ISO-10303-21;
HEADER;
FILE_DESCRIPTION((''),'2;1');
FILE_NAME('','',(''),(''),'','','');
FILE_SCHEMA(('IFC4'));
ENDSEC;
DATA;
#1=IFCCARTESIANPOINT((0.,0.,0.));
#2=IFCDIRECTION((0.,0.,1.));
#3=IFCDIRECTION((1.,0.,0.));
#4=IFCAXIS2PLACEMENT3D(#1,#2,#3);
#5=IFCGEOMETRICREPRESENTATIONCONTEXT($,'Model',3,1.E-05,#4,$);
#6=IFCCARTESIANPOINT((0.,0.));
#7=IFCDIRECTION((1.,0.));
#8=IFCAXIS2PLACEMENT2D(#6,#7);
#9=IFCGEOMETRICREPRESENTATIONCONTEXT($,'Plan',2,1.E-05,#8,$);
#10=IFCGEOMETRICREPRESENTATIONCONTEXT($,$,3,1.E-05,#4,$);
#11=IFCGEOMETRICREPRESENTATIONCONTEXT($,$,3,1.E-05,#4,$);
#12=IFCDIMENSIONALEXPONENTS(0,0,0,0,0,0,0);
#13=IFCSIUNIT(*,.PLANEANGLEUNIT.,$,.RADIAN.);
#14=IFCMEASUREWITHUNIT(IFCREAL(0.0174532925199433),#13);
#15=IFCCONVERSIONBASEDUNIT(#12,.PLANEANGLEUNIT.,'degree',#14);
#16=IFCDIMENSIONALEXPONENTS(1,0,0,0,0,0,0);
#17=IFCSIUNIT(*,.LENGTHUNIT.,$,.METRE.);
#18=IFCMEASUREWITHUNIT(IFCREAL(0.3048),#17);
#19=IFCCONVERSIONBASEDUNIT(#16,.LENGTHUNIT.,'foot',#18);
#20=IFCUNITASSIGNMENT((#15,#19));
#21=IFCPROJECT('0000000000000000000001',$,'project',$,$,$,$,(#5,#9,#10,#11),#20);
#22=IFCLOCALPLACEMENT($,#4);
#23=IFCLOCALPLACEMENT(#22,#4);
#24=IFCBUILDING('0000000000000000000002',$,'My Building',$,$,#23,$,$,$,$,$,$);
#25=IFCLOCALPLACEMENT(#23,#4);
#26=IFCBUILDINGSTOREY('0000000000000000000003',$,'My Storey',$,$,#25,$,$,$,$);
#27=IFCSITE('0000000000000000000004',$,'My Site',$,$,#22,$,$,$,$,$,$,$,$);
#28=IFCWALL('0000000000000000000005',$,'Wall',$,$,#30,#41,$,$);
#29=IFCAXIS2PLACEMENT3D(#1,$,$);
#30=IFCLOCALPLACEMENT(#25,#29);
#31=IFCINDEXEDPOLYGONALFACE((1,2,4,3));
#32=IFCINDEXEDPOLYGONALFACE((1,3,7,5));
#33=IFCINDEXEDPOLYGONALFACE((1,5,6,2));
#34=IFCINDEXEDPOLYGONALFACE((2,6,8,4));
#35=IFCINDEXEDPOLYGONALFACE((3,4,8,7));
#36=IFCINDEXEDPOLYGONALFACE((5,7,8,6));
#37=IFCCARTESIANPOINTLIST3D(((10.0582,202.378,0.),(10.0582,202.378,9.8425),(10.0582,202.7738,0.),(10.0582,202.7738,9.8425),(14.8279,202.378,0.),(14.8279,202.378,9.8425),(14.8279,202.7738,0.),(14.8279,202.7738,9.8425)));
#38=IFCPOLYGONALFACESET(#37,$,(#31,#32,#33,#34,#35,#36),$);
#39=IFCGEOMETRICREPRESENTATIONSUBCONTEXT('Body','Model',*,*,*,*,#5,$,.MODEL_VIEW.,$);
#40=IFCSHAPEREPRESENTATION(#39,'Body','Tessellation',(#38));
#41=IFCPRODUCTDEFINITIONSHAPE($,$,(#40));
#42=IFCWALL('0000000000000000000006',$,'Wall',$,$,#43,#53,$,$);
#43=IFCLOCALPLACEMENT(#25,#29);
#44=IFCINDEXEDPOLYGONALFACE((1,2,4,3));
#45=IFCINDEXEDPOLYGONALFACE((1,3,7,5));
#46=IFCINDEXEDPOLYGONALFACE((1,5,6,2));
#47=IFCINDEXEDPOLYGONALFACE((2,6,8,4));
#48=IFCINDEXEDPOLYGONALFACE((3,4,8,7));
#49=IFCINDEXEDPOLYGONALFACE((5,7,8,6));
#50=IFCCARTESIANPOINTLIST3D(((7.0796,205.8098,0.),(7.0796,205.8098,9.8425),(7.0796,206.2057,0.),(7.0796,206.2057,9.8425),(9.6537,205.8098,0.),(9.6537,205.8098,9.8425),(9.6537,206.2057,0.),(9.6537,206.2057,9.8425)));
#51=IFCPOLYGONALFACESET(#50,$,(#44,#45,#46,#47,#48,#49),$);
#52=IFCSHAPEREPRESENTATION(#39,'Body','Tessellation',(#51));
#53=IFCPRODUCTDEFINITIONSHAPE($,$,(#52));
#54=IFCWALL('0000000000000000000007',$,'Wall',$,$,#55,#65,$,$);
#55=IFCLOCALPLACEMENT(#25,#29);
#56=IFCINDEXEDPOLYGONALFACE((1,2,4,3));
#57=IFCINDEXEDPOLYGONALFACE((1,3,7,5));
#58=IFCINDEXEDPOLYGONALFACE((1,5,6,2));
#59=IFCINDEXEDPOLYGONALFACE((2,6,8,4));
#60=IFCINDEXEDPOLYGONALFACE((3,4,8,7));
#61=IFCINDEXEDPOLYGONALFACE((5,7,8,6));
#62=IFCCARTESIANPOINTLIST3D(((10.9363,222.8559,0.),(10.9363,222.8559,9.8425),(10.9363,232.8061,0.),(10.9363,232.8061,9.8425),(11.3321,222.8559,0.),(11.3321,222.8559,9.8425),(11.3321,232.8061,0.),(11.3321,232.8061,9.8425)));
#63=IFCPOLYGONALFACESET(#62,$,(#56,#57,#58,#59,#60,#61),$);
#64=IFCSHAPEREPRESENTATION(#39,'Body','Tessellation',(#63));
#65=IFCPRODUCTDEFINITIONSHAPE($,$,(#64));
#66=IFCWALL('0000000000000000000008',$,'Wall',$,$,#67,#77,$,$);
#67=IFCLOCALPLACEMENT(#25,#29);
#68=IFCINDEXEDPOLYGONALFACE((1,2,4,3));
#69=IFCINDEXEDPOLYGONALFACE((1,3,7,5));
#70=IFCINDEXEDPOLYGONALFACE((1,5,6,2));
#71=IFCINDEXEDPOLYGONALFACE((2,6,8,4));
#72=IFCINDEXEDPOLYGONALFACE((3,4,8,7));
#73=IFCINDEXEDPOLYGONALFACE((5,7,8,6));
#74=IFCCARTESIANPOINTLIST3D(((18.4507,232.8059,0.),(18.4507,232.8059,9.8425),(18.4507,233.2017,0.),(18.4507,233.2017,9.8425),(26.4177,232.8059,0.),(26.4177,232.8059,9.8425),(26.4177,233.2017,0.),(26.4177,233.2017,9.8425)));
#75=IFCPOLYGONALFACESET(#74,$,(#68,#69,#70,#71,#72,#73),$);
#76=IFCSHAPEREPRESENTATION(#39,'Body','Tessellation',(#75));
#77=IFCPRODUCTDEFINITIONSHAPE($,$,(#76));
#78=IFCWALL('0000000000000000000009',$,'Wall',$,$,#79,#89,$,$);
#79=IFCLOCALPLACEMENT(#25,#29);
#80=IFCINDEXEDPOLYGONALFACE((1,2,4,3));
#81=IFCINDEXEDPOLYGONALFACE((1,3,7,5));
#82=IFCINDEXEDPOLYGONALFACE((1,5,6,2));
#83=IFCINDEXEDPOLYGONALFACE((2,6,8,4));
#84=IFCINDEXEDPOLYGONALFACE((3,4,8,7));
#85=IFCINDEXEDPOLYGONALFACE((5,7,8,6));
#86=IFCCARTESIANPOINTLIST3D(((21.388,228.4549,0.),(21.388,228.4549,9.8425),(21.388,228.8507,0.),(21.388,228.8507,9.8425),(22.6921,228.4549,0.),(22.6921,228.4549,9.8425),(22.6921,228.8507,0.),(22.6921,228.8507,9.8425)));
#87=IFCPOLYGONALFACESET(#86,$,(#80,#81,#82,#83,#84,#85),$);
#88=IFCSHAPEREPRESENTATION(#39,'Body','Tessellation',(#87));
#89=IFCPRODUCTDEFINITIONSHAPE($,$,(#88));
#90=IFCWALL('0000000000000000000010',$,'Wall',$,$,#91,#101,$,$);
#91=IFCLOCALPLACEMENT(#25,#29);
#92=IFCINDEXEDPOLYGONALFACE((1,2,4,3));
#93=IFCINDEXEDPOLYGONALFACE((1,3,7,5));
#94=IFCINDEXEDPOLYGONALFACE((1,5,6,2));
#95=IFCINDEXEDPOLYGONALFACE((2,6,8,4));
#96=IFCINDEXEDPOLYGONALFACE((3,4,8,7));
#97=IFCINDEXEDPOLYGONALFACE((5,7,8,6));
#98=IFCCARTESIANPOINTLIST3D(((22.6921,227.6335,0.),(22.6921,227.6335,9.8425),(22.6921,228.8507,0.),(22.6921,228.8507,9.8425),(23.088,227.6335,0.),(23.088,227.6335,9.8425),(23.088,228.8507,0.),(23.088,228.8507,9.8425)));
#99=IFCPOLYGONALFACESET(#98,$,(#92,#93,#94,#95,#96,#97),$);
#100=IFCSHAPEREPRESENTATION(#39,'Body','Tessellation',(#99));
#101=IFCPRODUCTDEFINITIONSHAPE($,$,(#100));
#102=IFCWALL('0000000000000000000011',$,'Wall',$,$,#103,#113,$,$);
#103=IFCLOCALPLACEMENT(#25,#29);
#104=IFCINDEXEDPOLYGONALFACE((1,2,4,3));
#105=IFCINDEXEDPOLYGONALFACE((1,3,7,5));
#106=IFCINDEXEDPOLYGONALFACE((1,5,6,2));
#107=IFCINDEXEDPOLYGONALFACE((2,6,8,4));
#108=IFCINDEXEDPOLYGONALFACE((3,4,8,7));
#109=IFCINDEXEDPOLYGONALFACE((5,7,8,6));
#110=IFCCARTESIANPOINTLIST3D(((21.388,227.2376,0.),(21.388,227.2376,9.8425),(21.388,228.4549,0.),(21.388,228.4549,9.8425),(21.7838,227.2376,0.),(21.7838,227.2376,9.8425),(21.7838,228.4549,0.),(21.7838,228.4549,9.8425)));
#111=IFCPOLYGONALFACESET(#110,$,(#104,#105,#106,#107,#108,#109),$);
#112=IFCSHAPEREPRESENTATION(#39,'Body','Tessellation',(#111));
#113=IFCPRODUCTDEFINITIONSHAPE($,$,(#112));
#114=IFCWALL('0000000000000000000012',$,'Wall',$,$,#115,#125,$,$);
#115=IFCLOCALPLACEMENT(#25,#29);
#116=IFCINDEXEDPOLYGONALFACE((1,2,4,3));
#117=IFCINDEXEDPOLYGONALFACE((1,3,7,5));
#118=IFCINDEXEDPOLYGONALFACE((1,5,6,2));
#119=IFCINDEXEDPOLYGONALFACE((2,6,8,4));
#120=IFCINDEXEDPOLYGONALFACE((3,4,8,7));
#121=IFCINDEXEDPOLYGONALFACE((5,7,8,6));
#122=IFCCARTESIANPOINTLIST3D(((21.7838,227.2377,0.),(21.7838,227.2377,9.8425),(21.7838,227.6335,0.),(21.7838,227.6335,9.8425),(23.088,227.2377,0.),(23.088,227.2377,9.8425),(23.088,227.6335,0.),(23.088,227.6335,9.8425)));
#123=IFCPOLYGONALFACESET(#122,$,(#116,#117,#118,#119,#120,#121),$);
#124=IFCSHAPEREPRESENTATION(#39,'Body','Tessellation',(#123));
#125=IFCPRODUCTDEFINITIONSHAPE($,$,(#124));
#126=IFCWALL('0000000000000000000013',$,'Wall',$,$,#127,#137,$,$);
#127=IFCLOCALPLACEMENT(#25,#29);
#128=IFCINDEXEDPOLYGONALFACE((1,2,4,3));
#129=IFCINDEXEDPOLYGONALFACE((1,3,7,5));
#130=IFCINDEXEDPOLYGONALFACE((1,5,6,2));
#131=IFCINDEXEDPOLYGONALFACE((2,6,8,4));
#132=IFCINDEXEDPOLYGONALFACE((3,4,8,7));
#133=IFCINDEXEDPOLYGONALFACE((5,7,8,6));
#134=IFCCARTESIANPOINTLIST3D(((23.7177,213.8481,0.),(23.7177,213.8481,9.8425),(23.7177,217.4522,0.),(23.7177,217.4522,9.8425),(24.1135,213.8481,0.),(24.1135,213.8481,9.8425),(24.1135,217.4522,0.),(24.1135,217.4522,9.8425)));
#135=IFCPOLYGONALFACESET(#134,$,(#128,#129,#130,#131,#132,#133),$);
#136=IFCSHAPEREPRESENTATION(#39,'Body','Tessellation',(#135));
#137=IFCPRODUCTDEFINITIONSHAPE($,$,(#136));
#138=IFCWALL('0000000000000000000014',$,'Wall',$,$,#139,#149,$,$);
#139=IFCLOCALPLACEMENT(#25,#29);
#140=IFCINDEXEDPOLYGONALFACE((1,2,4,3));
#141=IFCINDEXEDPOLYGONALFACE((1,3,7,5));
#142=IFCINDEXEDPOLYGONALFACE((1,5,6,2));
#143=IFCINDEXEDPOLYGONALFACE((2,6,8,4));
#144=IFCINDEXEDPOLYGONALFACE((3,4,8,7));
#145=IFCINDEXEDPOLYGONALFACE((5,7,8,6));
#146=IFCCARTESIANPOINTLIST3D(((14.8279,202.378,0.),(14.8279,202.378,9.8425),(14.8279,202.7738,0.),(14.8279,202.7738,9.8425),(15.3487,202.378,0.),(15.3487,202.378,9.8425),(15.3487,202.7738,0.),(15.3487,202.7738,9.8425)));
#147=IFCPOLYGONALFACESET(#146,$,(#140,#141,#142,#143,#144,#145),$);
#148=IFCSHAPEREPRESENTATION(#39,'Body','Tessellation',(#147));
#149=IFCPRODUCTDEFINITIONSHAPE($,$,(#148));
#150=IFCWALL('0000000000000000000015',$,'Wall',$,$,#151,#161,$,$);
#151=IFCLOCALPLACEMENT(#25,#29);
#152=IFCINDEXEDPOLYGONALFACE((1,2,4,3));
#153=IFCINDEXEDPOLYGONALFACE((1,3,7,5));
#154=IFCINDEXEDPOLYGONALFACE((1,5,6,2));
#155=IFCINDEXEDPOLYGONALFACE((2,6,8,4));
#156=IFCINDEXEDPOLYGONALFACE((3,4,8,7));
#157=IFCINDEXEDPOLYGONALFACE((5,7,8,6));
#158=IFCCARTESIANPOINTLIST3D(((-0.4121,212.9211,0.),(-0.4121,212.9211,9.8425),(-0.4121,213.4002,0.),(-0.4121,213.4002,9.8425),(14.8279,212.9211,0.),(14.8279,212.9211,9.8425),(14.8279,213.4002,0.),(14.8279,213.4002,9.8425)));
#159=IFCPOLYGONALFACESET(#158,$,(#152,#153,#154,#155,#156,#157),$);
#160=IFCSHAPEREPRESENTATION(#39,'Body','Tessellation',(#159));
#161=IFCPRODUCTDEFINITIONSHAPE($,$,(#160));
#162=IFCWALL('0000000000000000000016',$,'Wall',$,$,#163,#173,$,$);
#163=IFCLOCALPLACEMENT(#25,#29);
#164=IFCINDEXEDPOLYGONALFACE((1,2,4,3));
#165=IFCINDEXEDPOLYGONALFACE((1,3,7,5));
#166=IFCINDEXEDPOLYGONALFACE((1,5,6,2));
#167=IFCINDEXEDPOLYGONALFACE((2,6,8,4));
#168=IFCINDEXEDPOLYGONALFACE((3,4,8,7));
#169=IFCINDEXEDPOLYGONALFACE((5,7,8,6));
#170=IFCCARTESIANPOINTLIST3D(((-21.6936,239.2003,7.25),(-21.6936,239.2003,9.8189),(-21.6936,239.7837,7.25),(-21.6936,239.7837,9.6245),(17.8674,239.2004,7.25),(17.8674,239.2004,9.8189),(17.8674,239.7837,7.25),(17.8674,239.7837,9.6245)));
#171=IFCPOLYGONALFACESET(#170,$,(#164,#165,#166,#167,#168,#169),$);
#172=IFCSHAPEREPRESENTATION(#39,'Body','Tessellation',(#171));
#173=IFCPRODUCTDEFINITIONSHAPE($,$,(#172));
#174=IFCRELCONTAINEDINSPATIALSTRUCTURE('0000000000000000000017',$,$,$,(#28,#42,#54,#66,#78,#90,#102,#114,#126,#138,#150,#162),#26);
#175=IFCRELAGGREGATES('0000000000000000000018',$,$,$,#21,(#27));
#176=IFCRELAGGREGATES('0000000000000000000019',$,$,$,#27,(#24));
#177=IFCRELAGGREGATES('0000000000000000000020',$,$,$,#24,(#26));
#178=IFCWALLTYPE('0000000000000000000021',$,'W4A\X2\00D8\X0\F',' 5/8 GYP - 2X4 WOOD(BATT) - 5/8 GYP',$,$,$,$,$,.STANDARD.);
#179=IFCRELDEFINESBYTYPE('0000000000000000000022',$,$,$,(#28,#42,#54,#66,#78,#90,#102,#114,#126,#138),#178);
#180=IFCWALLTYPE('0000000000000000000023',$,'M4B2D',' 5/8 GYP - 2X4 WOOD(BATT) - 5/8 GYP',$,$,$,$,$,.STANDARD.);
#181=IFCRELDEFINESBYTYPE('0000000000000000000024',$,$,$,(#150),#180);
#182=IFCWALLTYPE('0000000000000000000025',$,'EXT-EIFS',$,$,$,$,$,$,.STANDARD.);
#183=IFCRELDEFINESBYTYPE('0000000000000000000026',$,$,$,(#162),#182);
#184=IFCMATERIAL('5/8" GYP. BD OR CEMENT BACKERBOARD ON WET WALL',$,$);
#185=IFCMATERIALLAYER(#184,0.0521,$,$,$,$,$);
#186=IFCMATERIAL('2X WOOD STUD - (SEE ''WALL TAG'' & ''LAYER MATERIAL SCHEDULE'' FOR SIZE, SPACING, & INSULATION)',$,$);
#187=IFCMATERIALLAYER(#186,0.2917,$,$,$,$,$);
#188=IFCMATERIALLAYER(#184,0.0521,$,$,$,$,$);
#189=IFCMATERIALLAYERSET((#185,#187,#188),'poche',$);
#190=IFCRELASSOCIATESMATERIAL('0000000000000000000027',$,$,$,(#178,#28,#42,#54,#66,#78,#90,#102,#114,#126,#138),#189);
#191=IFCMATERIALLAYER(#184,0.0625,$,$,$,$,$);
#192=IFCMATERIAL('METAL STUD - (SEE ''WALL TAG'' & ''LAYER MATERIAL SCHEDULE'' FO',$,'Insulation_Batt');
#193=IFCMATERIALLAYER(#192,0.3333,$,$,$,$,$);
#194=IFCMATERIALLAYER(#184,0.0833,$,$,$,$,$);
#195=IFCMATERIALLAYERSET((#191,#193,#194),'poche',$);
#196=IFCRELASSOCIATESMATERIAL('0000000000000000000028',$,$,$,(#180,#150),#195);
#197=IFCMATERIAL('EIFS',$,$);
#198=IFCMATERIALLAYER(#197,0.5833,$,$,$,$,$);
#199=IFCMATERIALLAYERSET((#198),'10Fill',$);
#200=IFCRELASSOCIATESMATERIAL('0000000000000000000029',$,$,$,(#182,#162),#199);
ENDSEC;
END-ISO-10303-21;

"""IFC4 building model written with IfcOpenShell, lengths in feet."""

from ifc_helpers import new_model, entity, si_unit, converted_unit, frame, origin_with_axes, origin_2d_with_axis, place, context, subcontext, project, spatial, indexed_curve, outline, extrude, clip, halfspace, material, layer, layer_set, layer_usage, type_object, element, save


model = new_model("IFC4")

# Units and contexts
model_context = context("Model", 3, precision=1e-05, world=origin_with_axes())
plan_context = context("Plan", 2, precision=1e-05, world=origin_2d_with_axis())
context_of_model_1 = context(None, 3, precision=1e-05, world=origin_with_axes())
context_of_model_2 = context(None, 3, precision=1e-05, world=origin_with_axes())
body_context = subcontext(model_context, "Body", "Model", "MODEL_VIEW")
ifc_project = project(units=[converted_unit("PLANEANGLEUNIT", "degree", entity("IfcReal", 0.0174532925199433), si_unit("PLANEANGLEUNIT", "RADIAN"), dimensions=[0, 0, 0, 0, 0, 0, 0]), converted_unit("LENGTHUNIT", "foot", entity("IfcReal", 0.3048), si_unit("LENGTHUNIT", "METRE"), dimensions=[1, 0, 0, 0, 0, 0, 0])], contexts=[model_context, plan_context, context_of_model_1, context_of_model_2])

# Site, building, storey
site_placement = place(None, origin_with_axes())
site = spatial("IfcSite", under=ifc_project, at=site_placement, Name="My Site")
building_placement = place(site_placement, origin_with_axes())
building = spatial("IfcBuilding", under=site, at=building_placement, Name="My Building")
storey_placement = place(building_placement, origin_with_axes())
storey = spatial("IfcBuildingStorey", under=building, at=storey_placement, Name="My Storey")

# Walls
ifc_material_1 = material(Name="5/8\" GYP. BD OR CEMENT BACKERBOARD ON WET WALL")
ifc_layer_1 = layer(ifc_material_1, 0.0521)
ifc_material_2 = material(Name="2X WOOD STUD - (SEE 'WALL TAG' & 'LAYER MATERIAL SCHEDULE' FOR SIZE, SPACING, & INSULATION)")
ifc_layer_2 = layer(ifc_material_2, 0.2917)
ifc_layer_3 = layer(ifc_material_1, 0.0521)
ifc_layer_set_1 = layer_set([ifc_layer_1, ifc_layer_2, ifc_layer_3], Name="poche")
ifc_layer_usage_1 = layer_usage(ifc_layer_set_1, "AXIS2", "POSITIVE", 0.0)
wall_type_1 = type_object("IfcWallType", Name="W4AØF", Description=" 5/8 GYP - 2X4 WOOD(BATT) - 5/8 GYP", PredefinedType="STANDARD", material=ifc_layer_set_1)
wall_1_placement = place(storey_placement, frame((10.0582, 202.378, 0.0), z_axis=(0.0, 0.0, 1.0), x_axis=(1.0, 0.0, 0.0)))
element("IfcWall", 1, at=wall_1_placement, inside=storey, type_object=wall_type_1, material=ifc_layer_usage_1, Name="Wall", context=body_context, shape_type="SweptSolid", body=[
    extrude(outline(indexed_curve([(0.0, 0.0), (0.0, 0.3958), (4.7697, 0.3958), (4.7697, 0.0), (0.0, 0.0)], self_intersect=False)), origin_with_axes(), (0.0, 0.0, 1.0), 9.8425),
])
ifc_layer_usage_2 = layer_usage(ifc_layer_set_1, "AXIS2", "POSITIVE", 0.0)
wall_2_placement = place(storey_placement, frame((9.6537, 206.2057, 0.0), z_axis=(0.0, 0.0, 1.0), x_axis=(-1.0, 0.0, 0.0)))
element("IfcWall", 2, at=wall_2_placement, inside=storey, type_object=wall_type_1, material=ifc_layer_usage_2, Name="Wall", context=body_context, shape_type="SweptSolid", body=[
    extrude(outline(indexed_curve([(0.0, 0.0), (0.0, 0.3958), (2.5741, 0.3958), (2.5741, 0.0), (0.0, 0.0)], self_intersect=False)), origin_with_axes(), (0.0, 0.0, 1.0), 9.8425),
])
ifc_layer_usage_3 = layer_usage(ifc_layer_set_1, "AXIS2", "POSITIVE", 0.0)
wall_3_placement = place(storey_placement, frame((10.9363, 232.8061, 0.0), z_axis=(0.0, 0.0, 1.0), x_axis=(-0.000001, -1.0, 0.0)))
element("IfcWall", 3, at=wall_3_placement, inside=storey, type_object=wall_type_1, material=ifc_layer_usage_3, Name="Wall", context=body_context, shape_type="SweptSolid", body=[
    extrude(outline(indexed_curve([(0.0, 0.0), (0.0, 0.3958), (9.9502, 0.3958), (9.9502, 0.0), (0.0, 0.0)], self_intersect=False)), origin_with_axes(), (0.0, 0.0, 1.0), 9.8425),
])
ifc_layer_usage_4 = layer_usage(ifc_layer_set_1, "AXIS2", "POSITIVE", 0.0)
wall_4_placement = place(storey_placement, frame((18.4507, 232.8059, 0.0), z_axis=(0.0, 0.0, 1.0), x_axis=(1.0, 0.0, 0.0)))
element("IfcWall", 4, at=wall_4_placement, inside=storey, type_object=wall_type_1, material=ifc_layer_usage_4, Name="Wall", context=body_context, shape_type="SweptSolid", body=[
    extrude(outline(indexed_curve([(0.0, 0.0), (0.0, 0.3958), (7.967, 0.3958), (7.967, 0.0), (0.0, 0.0)], self_intersect=False)), origin_with_axes(), (0.0, 0.0, 1.0), 9.8425),
])

# Walls
ifc_layer_usage_5 = layer_usage(ifc_layer_set_1, "AXIS2", "POSITIVE", 0.0)
wall_5_placement = place(storey_placement, frame((22.6921, 228.8507, 0.0), z_axis=(0.0, 0.0, 1.0), x_axis=(-1.0, 0.0, 0.0)))
element("IfcWall", 5, at=wall_5_placement, inside=storey, type_object=wall_type_1, material=ifc_layer_usage_5, Name="Wall", context=body_context, shape_type="SweptSolid", body=[
    extrude(outline(indexed_curve([(0.0, 0.0), (0.0, 0.3958), (1.3042, 0.3958), (1.3042, 0.0), (0.0, 0.0)], self_intersect=False)), origin_with_axes(), (0.0, 0.0, 1.0), 9.8425),
])
ifc_layer_usage_6 = layer_usage(ifc_layer_set_1, "AXIS2", "POSITIVE", 0.0)
wall_6_placement = place(storey_placement, frame((23.088, 227.6335, 0.0), z_axis=(0.0, 0.0, 1.0), x_axis=(0.0, 1.0, 0.0)))
element("IfcWall", 6, at=wall_6_placement, inside=storey, type_object=wall_type_1, material=ifc_layer_usage_6, Name="Wall", context=body_context, shape_type="SweptSolid", body=[
    extrude(outline(indexed_curve([(0.0, 0.0), (0.0, 0.3958), (1.2172, 0.3958), (1.2172, 0.0), (0.0, 0.0)], self_intersect=False)), origin_with_axes(), (0.0, 0.0, 1.0), 9.8425),
])
ifc_layer_usage_7 = layer_usage(ifc_layer_set_1, "AXIS2", "POSITIVE", 0.0)
wall_7_placement = place(storey_placement, frame((21.388, 228.4549, 0.0), z_axis=(0.0, 0.0, 1.0), x_axis=(0.0, -1.0, 0.0)))
element("IfcWall", 7, at=wall_7_placement, inside=storey, type_object=wall_type_1, material=ifc_layer_usage_7, Name="Wall", context=body_context, shape_type="SweptSolid", body=[
    extrude(outline(indexed_curve([(0.0, 0.0), (0.0, 0.3958), (1.2172, 0.3958), (1.2172, 0.0), (0.0, 0.0)], self_intersect=False)), origin_with_axes(), (0.0, 0.0, 1.0), 9.8425),
])
ifc_layer_usage_8 = layer_usage(ifc_layer_set_1, "AXIS2", "POSITIVE", 0.0)
wall_8_placement = place(storey_placement, frame((21.7838, 227.2377, 0.0), z_axis=(0.0, 0.0, 1.0), x_axis=(1.0, 0.0, 0.0)))
element("IfcWall", 8, at=wall_8_placement, inside=storey, type_object=wall_type_1, material=ifc_layer_usage_8, Name="Wall", context=body_context, shape_type="SweptSolid", body=[
    extrude(outline(indexed_curve([(0.0, 0.0), (0.0, 0.3958), (1.3042, 0.3958), (1.3042, 0.0), (0.0, 0.0)], self_intersect=False)), origin_with_axes(), (0.0, 0.0, 1.0), 9.8425),
])
ifc_layer_usage_9 = layer_usage(ifc_layer_set_1, "AXIS2", "POSITIVE", 0.0)
wall_9_placement = place(storey_placement, frame((23.7177, 217.4522, 0.0), z_axis=(0.0, 0.0, 1.0), x_axis=(0.0, -1.0, 0.0)))
element("IfcWall", 9, at=wall_9_placement, inside=storey, type_object=wall_type_1, material=ifc_layer_usage_9, Name="Wall", context=body_context, shape_type="SweptSolid", body=[
    extrude(outline(indexed_curve([(0.0, 0.0), (0.0, 0.3958), (3.6041, 0.3958), (3.6041, 0.0), (0.0, 0.0)], self_intersect=False)), origin_with_axes(), (0.0, 0.0, 1.0), 9.8425),
])

# Walls
ifc_layer_usage_10 = layer_usage(ifc_layer_set_1, "AXIS2", "POSITIVE", 0.0)
wall_10_placement = place(storey_placement, frame((15.3487, 202.7738, 0.0), z_axis=(0.0, 0.0, 1.0), x_axis=(-1.0, 0.0, 0.0)))
element("IfcWall", 10, at=wall_10_placement, inside=storey, type_object=wall_type_1, material=ifc_layer_usage_10, Name="Wall", context=body_context, shape_type="SweptSolid", body=[
    extrude(outline(indexed_curve([(0.0, 0.0), (0.0, 0.3958), (0.5208, 0.3958), (0.5208, 0.0), (0.0, 0.0)], self_intersect=False)), origin_with_axes(), (0.0, 0.0, 1.0), 9.8425),
])
ifc_layer_4 = layer(ifc_material_1, 0.0625)
ifc_material_3 = material(Name="METAL STUD - (SEE 'WALL TAG' & 'LAYER MATERIAL SCHEDULE' FO", Category="Insulation_Batt")
ifc_layer_5 = layer(ifc_material_3, 0.3333)
ifc_layer_6 = layer(ifc_material_1, 0.0833)
ifc_layer_set_2 = layer_set([ifc_layer_4, ifc_layer_5, ifc_layer_6], Name="poche")
ifc_layer_usage_11 = layer_usage(ifc_layer_set_2, "AXIS2", "POSITIVE", 0.0)
wall_type_2 = type_object("IfcWallType", Name="M4B2D", Description=" 5/8 GYP - 2X4 WOOD(BATT) - 5/8 GYP", PredefinedType="STANDARD", material=ifc_layer_set_2)
wall_11_placement = place(storey_placement, frame((14.8279, 213.4002, 0.0), z_axis=(0.0, 0.0, 1.0), x_axis=(-1.0, 0.0, 0.0)))
element("IfcWall", 11, at=wall_11_placement, inside=storey, type_object=wall_type_2, material=ifc_layer_usage_11, Name="Wall", context=body_context, shape_type="SweptSolid", body=[
    extrude(outline(indexed_curve([(0.0, 0.0), (0.0, 0.4792), (15.24, 0.4792), (15.24, 0.0), (0.0, 0.0)], self_intersect=False)), origin_with_axes(), (0.0, 0.0, 1.0), 9.8425),
])
ifc_material_4 = material(Name="EIFS")
ifc_layer_7 = layer(ifc_material_4, 0.5833)
ifc_layer_set_3 = layer_set([ifc_layer_7], Name="10Fill")
ifc_layer_usage_12 = layer_usage(ifc_layer_set_3, "AXIS2", "POSITIVE", 0.0)
wall_type_3 = type_object("IfcWallType", Name="EXT-EIFS", PredefinedType="STANDARD", material=ifc_layer_set_3)
wall_12_placement = place(storey_placement, frame((17.8674, 239.7837, 7.25), z_axis=(0.0, 0.0, 1.0), x_axis=(-1.0, 0.0, 0.0)))
element("IfcWall", 12, at=wall_12_placement, inside=storey, type_object=wall_type_3, material=ifc_layer_usage_12, Name="Wall", context=body_context, shape_type="Clipping", body=[
    clip(extrude(outline(indexed_curve([(0.0, 0.0), (0.0, 0.5833), (39.561, 0.5833), (39.561, 0.0), (0.0, 0.0)], self_intersect=False)), origin_with_axes(), (0.0, 0.0, 1.0), 9.8189), halfspace(frame((0.0, 0.5834, 2.5689), z_axis=(0.0, -0.316146, 0.948711), x_axis=(1.0, 0.0, 0.0)), False)),
])

save(model, "model.ifc")
